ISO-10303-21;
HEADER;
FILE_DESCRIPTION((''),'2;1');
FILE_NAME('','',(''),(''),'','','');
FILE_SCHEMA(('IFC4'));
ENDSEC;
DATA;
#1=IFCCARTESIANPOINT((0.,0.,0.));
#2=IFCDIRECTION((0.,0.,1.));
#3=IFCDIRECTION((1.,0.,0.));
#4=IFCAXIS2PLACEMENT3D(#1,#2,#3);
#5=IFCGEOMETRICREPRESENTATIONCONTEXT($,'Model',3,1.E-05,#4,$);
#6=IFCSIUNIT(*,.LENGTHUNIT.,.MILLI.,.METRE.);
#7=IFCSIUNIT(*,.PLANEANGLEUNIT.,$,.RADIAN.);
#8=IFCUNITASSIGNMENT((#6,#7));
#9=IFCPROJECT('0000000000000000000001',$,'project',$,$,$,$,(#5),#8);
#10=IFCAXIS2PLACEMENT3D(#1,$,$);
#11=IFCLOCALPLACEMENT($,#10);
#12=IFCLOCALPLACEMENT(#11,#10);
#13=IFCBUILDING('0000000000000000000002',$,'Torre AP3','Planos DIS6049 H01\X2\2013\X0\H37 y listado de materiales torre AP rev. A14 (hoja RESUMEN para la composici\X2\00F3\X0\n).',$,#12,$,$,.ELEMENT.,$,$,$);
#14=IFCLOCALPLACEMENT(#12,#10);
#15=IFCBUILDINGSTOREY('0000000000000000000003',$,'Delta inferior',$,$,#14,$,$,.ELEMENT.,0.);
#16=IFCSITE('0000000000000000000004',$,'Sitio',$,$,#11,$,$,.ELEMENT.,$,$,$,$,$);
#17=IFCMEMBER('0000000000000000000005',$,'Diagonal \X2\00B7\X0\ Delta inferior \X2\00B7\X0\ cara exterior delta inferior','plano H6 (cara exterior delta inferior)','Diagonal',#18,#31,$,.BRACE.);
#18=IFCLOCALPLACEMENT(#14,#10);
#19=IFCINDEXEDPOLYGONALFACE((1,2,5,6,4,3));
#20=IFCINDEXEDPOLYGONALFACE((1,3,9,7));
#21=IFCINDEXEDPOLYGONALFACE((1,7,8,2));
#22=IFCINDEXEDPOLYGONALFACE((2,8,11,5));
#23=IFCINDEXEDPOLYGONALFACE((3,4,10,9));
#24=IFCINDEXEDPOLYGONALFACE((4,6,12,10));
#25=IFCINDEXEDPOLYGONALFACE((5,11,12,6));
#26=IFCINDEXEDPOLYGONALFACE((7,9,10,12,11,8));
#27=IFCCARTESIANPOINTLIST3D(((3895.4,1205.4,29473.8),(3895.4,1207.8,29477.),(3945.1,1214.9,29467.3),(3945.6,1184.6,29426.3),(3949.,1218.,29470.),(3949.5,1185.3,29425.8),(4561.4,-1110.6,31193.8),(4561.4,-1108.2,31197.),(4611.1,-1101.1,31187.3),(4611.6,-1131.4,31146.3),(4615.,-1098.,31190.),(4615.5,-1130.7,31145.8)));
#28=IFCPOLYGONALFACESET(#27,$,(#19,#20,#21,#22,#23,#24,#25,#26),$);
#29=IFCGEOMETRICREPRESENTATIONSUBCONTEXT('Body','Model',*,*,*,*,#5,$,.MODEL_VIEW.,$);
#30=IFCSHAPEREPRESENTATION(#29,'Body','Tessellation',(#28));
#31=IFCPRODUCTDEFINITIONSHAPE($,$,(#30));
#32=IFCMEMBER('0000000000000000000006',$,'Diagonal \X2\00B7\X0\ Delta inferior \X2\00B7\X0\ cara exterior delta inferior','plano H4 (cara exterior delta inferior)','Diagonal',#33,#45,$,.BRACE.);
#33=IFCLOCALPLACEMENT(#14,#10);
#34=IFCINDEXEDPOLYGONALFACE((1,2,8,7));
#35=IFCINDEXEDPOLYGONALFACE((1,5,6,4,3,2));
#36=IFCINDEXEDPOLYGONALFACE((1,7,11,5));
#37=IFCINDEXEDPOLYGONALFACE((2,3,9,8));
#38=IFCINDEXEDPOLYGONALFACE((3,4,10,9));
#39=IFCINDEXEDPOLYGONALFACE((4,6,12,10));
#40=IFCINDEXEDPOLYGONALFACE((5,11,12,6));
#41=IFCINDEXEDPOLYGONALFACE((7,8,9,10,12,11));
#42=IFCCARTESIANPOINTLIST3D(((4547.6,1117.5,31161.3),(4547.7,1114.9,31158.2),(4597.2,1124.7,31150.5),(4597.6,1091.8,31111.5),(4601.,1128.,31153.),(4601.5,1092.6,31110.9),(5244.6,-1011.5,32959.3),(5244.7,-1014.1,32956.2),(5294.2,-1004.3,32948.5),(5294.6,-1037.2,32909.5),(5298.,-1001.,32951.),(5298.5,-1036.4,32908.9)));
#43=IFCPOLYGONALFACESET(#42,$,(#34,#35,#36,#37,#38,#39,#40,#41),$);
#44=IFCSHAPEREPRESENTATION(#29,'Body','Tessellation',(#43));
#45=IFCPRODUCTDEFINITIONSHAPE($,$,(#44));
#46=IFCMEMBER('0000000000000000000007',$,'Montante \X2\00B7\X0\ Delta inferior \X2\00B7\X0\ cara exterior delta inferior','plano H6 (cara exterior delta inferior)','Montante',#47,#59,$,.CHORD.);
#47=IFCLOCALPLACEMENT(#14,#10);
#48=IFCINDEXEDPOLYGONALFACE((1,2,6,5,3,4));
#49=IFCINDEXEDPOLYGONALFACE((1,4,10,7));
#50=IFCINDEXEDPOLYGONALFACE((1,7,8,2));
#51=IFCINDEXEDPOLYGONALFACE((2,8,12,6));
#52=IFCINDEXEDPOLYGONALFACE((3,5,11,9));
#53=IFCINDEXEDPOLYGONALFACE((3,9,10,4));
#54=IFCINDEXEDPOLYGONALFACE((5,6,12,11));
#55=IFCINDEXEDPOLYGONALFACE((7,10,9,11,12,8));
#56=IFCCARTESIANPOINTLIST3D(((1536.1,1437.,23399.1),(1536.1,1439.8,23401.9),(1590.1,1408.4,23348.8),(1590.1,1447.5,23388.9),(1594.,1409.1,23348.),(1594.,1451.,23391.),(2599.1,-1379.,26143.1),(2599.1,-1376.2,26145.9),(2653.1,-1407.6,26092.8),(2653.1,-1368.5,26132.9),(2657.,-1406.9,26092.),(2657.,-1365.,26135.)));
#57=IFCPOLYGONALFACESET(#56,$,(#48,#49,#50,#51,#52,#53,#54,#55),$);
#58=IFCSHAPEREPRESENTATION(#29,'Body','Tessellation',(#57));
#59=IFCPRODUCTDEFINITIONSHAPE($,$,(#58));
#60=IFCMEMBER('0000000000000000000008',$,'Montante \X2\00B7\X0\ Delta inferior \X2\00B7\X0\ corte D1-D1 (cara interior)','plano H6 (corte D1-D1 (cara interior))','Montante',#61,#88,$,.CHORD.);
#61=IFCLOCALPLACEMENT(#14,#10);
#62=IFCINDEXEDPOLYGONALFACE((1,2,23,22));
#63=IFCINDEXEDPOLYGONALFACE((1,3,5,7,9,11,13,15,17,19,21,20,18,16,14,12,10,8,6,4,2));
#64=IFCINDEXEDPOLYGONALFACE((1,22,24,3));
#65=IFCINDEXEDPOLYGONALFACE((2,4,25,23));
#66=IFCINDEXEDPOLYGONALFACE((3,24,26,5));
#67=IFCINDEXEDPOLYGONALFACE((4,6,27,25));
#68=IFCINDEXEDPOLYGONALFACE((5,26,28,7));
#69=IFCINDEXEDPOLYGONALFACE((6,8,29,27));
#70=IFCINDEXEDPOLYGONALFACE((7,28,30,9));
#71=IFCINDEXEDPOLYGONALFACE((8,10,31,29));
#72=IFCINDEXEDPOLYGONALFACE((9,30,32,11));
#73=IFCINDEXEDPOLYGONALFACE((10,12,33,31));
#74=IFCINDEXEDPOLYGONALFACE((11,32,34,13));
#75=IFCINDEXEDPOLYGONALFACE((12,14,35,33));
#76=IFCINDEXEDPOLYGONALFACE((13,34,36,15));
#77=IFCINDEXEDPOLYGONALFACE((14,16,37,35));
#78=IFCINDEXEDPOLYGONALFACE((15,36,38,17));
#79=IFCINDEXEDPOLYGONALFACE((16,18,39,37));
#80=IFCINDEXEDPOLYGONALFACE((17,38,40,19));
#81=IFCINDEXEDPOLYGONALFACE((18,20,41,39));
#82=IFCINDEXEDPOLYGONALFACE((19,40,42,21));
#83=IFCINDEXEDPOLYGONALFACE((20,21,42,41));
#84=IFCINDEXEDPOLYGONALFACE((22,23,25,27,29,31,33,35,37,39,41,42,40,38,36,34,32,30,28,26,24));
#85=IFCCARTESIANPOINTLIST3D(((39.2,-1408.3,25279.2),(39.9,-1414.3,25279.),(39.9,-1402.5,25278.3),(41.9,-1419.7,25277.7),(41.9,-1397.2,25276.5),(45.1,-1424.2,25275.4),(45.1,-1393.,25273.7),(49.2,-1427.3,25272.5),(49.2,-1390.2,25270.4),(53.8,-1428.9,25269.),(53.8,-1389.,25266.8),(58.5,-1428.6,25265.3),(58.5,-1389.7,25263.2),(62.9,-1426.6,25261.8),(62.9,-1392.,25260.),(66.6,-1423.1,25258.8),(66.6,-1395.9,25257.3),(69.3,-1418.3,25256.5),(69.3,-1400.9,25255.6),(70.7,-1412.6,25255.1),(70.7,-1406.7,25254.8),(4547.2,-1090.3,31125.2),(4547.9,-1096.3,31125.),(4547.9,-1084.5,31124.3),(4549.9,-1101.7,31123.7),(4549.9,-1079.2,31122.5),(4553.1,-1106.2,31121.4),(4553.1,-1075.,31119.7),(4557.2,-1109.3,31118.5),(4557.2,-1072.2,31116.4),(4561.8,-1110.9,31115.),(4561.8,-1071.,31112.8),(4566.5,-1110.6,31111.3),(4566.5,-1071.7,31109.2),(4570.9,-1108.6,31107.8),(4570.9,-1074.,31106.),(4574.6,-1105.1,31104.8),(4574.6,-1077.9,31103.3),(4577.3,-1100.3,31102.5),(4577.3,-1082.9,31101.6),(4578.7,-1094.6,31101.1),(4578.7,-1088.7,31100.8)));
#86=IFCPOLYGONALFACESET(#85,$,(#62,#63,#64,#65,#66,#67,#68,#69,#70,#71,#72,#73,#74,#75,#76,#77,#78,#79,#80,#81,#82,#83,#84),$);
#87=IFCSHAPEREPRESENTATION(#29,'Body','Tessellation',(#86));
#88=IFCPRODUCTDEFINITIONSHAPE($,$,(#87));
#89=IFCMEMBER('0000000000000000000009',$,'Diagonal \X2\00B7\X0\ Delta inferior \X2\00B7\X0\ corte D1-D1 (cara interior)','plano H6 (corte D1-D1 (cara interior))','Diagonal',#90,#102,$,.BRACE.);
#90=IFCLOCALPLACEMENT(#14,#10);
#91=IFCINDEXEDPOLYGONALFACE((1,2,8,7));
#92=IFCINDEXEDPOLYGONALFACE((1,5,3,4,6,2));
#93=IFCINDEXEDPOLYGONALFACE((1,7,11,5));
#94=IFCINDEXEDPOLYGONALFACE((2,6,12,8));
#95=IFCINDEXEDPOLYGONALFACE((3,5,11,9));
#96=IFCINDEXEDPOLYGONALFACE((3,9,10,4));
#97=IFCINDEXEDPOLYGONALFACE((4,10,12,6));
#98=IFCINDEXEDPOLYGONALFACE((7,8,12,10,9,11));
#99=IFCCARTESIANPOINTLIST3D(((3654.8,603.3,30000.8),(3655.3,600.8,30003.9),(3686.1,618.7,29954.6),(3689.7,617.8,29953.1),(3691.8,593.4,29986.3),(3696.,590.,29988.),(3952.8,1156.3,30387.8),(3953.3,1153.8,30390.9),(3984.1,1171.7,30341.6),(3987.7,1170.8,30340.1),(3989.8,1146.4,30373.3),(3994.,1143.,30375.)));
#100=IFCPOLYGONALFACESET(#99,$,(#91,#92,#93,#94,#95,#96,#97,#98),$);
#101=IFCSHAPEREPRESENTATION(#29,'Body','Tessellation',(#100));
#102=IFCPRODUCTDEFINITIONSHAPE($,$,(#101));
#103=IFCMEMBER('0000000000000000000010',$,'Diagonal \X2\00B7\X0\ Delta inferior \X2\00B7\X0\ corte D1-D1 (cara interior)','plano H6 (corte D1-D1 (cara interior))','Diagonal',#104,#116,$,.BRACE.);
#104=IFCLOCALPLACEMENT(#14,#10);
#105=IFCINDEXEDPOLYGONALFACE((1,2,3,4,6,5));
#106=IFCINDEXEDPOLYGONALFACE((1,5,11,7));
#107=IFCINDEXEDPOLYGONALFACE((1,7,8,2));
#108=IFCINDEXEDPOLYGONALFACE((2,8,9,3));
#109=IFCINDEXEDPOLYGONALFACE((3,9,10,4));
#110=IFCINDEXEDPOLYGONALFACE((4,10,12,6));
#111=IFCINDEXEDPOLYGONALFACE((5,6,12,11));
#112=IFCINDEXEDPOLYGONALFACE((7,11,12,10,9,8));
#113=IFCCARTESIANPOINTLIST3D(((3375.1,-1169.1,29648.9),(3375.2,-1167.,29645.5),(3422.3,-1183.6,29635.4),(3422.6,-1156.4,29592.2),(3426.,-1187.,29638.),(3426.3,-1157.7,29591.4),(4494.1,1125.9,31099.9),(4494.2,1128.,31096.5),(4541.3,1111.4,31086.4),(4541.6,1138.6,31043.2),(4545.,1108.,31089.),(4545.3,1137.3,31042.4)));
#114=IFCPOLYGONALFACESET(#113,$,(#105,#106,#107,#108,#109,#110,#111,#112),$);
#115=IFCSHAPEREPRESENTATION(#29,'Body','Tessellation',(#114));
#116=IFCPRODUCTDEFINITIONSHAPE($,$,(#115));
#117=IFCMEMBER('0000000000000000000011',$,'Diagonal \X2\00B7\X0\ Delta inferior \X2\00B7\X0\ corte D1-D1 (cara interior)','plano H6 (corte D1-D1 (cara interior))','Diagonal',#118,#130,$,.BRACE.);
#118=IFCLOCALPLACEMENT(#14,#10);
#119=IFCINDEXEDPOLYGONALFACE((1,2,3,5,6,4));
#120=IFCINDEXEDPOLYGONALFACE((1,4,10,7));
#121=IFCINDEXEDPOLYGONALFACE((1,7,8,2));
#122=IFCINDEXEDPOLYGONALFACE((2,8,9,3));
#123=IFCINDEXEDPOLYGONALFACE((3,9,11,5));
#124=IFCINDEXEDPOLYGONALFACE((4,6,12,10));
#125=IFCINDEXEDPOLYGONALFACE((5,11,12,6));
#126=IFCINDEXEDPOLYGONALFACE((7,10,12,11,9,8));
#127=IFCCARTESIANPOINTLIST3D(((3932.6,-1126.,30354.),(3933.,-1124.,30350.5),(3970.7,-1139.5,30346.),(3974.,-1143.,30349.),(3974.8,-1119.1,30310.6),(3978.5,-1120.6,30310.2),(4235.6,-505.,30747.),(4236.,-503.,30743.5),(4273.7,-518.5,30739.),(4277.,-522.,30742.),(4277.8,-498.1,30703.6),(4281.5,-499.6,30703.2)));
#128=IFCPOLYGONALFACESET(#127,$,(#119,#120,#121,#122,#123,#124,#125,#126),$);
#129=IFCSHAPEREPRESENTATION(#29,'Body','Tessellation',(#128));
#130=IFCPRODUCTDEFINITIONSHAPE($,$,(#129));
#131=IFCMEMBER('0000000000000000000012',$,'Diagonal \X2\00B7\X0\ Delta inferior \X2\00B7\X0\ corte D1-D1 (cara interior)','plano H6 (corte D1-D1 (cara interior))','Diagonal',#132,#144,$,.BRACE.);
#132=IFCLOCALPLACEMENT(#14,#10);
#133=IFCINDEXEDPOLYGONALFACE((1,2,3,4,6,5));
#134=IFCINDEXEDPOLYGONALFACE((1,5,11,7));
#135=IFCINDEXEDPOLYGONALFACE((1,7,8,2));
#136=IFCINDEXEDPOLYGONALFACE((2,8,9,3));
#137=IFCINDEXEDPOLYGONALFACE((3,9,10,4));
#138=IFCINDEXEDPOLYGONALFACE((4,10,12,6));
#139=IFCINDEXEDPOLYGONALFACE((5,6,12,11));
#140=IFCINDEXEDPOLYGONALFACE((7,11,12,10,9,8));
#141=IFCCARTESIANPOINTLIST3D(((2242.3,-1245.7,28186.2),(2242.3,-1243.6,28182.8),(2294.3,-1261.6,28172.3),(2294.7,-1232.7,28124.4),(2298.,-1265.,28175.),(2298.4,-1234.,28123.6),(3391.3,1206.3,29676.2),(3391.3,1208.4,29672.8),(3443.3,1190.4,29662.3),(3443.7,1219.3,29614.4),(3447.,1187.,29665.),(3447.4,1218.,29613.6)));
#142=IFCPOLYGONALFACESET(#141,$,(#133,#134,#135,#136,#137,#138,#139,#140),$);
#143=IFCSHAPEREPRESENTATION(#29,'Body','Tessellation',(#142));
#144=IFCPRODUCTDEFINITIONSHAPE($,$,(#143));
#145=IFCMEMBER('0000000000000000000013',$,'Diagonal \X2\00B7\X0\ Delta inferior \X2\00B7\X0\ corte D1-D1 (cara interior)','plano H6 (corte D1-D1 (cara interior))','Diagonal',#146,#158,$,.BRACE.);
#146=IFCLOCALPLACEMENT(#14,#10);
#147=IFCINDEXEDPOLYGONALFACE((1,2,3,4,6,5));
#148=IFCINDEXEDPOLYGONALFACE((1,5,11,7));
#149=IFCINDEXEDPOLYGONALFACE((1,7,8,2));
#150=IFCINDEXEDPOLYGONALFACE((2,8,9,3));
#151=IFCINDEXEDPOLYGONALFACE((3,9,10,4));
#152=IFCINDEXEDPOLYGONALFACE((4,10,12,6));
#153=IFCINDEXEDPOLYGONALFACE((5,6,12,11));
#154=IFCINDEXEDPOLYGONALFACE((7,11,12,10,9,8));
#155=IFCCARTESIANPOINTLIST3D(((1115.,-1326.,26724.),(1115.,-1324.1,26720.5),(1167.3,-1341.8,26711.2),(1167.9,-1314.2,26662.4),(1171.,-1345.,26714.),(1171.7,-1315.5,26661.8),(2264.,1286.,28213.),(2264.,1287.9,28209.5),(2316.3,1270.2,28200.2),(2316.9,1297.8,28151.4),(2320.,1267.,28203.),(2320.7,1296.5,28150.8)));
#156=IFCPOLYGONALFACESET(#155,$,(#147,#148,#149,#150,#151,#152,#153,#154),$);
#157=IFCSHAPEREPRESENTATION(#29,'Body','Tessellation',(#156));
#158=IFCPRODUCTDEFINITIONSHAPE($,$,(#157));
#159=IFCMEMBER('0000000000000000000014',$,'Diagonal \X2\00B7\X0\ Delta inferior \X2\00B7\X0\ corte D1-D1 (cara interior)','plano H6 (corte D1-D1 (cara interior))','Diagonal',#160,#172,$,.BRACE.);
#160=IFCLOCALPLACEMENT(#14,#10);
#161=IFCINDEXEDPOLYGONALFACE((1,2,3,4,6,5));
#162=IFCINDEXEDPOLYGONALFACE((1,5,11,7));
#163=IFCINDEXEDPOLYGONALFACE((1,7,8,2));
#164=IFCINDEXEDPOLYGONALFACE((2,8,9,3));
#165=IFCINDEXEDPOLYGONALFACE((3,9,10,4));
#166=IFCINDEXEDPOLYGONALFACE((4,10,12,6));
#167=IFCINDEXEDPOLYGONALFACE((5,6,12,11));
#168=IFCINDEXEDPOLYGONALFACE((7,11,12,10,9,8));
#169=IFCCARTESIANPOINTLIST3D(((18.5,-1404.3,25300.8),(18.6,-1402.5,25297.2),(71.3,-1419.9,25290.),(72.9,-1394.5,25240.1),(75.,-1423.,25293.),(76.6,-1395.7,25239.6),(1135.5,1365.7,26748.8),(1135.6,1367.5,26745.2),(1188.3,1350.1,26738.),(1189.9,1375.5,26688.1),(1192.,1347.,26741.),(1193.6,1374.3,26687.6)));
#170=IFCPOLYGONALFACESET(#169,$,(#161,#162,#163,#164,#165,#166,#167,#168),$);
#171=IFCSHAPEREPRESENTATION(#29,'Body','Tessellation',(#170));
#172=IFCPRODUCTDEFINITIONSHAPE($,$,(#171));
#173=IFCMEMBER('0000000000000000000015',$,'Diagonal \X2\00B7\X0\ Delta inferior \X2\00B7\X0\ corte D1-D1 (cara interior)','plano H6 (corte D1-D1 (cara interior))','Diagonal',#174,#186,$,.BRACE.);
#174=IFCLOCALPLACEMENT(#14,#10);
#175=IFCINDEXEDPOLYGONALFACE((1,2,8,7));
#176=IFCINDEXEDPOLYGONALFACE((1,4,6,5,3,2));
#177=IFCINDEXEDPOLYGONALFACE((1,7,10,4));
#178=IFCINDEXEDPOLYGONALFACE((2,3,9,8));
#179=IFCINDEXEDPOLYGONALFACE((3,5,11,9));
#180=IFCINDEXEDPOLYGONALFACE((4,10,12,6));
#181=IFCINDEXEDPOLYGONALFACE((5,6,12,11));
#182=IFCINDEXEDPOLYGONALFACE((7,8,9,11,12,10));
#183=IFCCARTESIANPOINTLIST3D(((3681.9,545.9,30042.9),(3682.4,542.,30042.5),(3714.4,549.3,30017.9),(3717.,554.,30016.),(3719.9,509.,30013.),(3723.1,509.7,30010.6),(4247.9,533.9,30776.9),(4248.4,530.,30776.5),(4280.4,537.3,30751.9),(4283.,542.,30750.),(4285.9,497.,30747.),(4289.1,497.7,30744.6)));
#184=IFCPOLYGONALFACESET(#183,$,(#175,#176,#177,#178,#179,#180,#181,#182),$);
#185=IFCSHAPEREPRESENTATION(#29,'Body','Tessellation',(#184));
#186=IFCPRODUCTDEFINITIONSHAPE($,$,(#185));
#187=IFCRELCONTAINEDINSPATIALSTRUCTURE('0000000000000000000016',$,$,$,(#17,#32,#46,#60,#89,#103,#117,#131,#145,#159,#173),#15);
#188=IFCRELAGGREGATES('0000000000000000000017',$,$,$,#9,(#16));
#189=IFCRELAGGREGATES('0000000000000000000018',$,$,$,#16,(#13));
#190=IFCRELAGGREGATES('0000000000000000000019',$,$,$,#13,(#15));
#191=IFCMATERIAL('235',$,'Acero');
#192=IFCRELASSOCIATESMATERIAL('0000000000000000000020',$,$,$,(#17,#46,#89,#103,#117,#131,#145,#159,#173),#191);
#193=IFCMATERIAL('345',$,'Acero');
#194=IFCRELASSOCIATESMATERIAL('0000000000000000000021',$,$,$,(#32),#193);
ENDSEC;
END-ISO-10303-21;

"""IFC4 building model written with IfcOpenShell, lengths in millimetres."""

from ifc_helpers import new_model, si_unit, frame, frame_2d, origin, origin_with_axes, place, context, subcontext, project, spatial, circle, l_section, extrude, material, element, save


model = new_model("IFC4")

# Units and contexts
model_context = context("Model", 3, precision=1e-05, world=origin_with_axes())
body_context = subcontext(model_context, "Body", "Model", "MODEL_VIEW")
ifc_project = project(units=[si_unit("LENGTHUNIT", "METRE", prefix="MILLI"), si_unit("PLANEANGLEUNIT", "RADIAN")], contexts=[model_context])

# Site, building, storey
site_placement = place(None, origin())
site = spatial("IfcSite", under=ifc_project, at=site_placement, Name="Sitio", CompositionType="ELEMENT")
building_placement = place(site_placement, origin())
building = spatial("IfcBuilding", under=site, at=building_placement, Name="Torre AP3", Description="Planos DIS6049 H01–H37 y listado de materiales torre AP rev. A14 (hoja RESUMEN para la composición).", CompositionType="ELEMENT")
storey_placement = place(building_placement, origin())
storey = spatial("IfcBuildingStorey", under=building, at=storey_placement, Name="Delta inferior", CompositionType="ELEMENT", Elevation=0.0)

# Members
ifc_material_1 = material(Name="235", Category="Acero")
ifc_material_2 = material(Name="345", Category="Acero")
member_1_placement = place(storey_placement, frame((3949.0, 1218.0, 29470.0), z_axis=(0.224946, -0.782244, 0.580941), x_axis=(-0.974336, -0.185683, 0.127247)))
element("IfcMember", 1, at=member_1_placement, inside=storey, material=ifc_material_1, Name="Diagonal · Delta inferior · cara exterior delta inferior", Description="plano H6 (cara exterior delta inferior)", ObjectType="Diagonal", PredefinedType="BRACE", context=body_context, shape_type="SweptSolid", body=[
    extrude(l_section(Depth=55.0, Width=55.0, Thickness=4.0, at=frame_2d((27.5, 27.5))), None, (0.0, 0.0, 1.0), 2960.7),
])
member_2_placement = place(storey_placement, frame((4601.0, 1128.0, 31153.0), z_axis=(0.242646, -0.741166, 0.625936), x_axis=(-0.97008, -0.190866, 0.150051)))
element("IfcMember", 2, at=member_2_placement, inside=storey, material=ifc_material_2, Name="Diagonal · Delta inferior · cara exterior delta inferior", Description="plano H4 (cara exterior delta inferior)", ObjectType="Diagonal", PredefinedType="BRACE", context=body_context, shape_type="SweptSolid", body=[
    extrude(l_section(Depth=55.0, Width=55.0, Thickness=4.0, at=frame_2d((27.5, 27.5))), None, (0.0, 0.0, 1.0), 2872.5),
])
member_3_placement = place(storey_placement, frame((1594.0, 1451.0, 23391.0), z_axis=(0.260987, -0.691382, 0.673704), x_axis=(-0.965342, -0.18692, 0.18214)))
element("IfcMember", 3, at=member_3_placement, inside=storey, material=ifc_material_1, Name="Montante · Delta inferior · cara exterior delta inferior", Description="plano H6 (cara exterior delta inferior)", ObjectType="Montante", PredefinedType="CHORD", context=body_context, shape_type="SweptSolid", body=[
    extrude(l_section(Depth=60.0, Width=60.0, Thickness=4.0, at=frame_2d((30.0, 30.0))), None, (0.0, 0.0, 1.0), 4073.0),
])
member_4_placement = place(storey_placement, frame((4563.0, -1091.0, 31113.0), z_axis=(-0.610087, -0.043036, -0.791165), x_axis=(-0.792334, 0.033137, 0.609187)))
element("IfcMember", 4, at=member_4_placement, inside=storey, Name="Montante · Delta inferior · corte D1-D1 (cara interior)", Description="plano H6 (corte D1-D1 (cara interior))", ObjectType="Montante", PredefinedType="CHORD", context=body_context, shape_type="SweptSolid", body=[
    extrude(circle(Radius=20.0), None, (0.0, 0.0, 1.0), 7389.1),
])
member_5_placement = place(storey_placement, frame((3994.0, 1143.0, 30375.0), z_axis=(-0.403891, -0.749503, -0.524516), x_axis=(-0.904178, 0.239916, 0.353414)))
element("IfcMember", 5, at=member_5_placement, inside=storey, material=ifc_material_1, Name="Diagonal · Delta inferior · corte D1-D1 (cara interior)", Description="plano H6 (corte D1-D1 (cara interior))", ObjectType="Diagonal", PredefinedType="BRACE", context=body_context, shape_type="SweptSolid", body=[
    extrude(l_section(Depth=45.0, Width=45.0, Thickness=4.0, at=frame_2d((22.5, 22.5))), None, (0.0, 0.0, 1.0), 737.8),
])
member_6_placement = place(storey_placement, frame((4545.0, 1108.0, 31089.0), z_axis=(-0.381032, -0.781472, -0.494081), x_axis=(-0.924547, 0.325107, 0.198793)))
element("IfcMember", 6, at=member_6_placement, inside=storey, material=ifc_material_1, Name="Diagonal · Delta inferior · corte D1-D1 (cara interior)", Description="plano H6 (corte D1-D1 (cara interior))", ObjectType="Diagonal", PredefinedType="BRACE", context=body_context, shape_type="SweptSolid", body=[
    extrude(l_section(Depth=55.0, Width=55.0, Thickness=4.0, at=frame_2d((27.5, 27.5))), None, (0.0, 0.0, 1.0), 2936.8),
])
member_7_placement = place(storey_placement, frame((4277.0, -522.0, 30742.0), z_axis=(-0.38117, -0.78121, -0.494389), x_axis=(-0.919056, 0.378167, 0.111023)))
element("IfcMember", 7, at=member_7_placement, inside=storey, material=ifc_material_1, Name="Diagonal · Delta inferior · corte D1-D1 (cara interior)", Description="plano H6 (corte D1-D1 (cara interior))", ObjectType="Diagonal", PredefinedType="BRACE", context=body_context, shape_type="SweptSolid", body=[
    extrude(l_section(Depth=45.0, Width=45.0, Thickness=4.0, at=frame_2d((22.5, 22.5))), None, (0.0, 0.0, 1.0), 794.9),
])
member_8_placement = place(storey_placement, frame((3447.0, 1187.0, 29665.0), z_axis=(-0.371757, -0.79334, -0.482087), x_axis=(-0.928304, 0.321616, 0.18659)))
element("IfcMember", 8, at=member_8_placement, inside=storey, material=ifc_material_1, Name="Diagonal · Delta inferior · corte D1-D1 (cara interior)", Description="plano H6 (corte D1-D1 (cara interior))", ObjectType="Diagonal", PredefinedType="BRACE", context=body_context, shape_type="SweptSolid", body=[
    extrude(l_section(Depth=60.0, Width=60.0, Thickness=4.0, at=frame_2d((30.0, 30.0))), None, (0.0, 0.0, 1.0), 3090.7),
])
member_9_placement = place(storey_placement, frame((2320.0, 1267.0, 28203.0), z_axis=(-0.356979, -0.811514, -0.462613), x_axis=(-0.934048, 0.315929, 0.166565)))
element("IfcMember", 9, at=member_9_placement, inside=storey, material=ifc_material_1, Name="Diagonal · Delta inferior · corte D1-D1 (cara interior)", Description="plano H6 (corte D1-D1 (cara interior))", ObjectType="Diagonal", PredefinedType="BRACE", context=body_context, shape_type="SweptSolid", body=[
    extrude(l_section(Depth=60.0, Width=60.0, Thickness=4.0, at=frame_2d((30.0, 30.0))), None, (0.0, 0.0, 1.0), 3218.7),
])
member_10_placement = place(storey_placement, frame((1192.0, 1347.0, 26741.0), z_axis=(-0.336524, -0.834531, -0.436246), x_axis=(-0.94128, 0.311519, 0.130181)))
element("IfcMember", 10, at=member_10_placement, inside=storey, material=ifc_material_1, Name="Diagonal · Delta inferior · corte D1-D1 (cara interior)", Description="plano H6 (corte D1-D1 (cara interior))", ObjectType="Diagonal", PredefinedType="BRACE", context=body_context, shape_type="SweptSolid", body=[
    extrude(l_section(Depth=60.0, Width=60.0, Thickness=4.0, at=frame_2d((30.0, 30.0))), None, (0.0, 0.0, 1.0), 3319.2),
])
member_11_placement = place(storey_placement, frame((3717.0, 554.0, 30016.0), z_axis=(0.610598, -0.012946, 0.791835), x_axis=(-0.780393, -0.179966, 0.598832)))
element("IfcMember", 11, at=member_11_placement, inside=storey, material=ifc_material_1, Name="Diagonal · Delta inferior · corte D1-D1 (cara interior)", Description="plano H6 (corte D1-D1 (cara interior))", ObjectType="Diagonal", PredefinedType="BRACE", context=body_context, shape_type="SweptSolid", body=[
    extrude(l_section(Depth=45.0, Width=45.0, Thickness=4.0, at=frame_2d((22.5, 22.5))), None, (0.0, 0.0, 1.0), 927.0),
])

save(model, "model.ifc")
